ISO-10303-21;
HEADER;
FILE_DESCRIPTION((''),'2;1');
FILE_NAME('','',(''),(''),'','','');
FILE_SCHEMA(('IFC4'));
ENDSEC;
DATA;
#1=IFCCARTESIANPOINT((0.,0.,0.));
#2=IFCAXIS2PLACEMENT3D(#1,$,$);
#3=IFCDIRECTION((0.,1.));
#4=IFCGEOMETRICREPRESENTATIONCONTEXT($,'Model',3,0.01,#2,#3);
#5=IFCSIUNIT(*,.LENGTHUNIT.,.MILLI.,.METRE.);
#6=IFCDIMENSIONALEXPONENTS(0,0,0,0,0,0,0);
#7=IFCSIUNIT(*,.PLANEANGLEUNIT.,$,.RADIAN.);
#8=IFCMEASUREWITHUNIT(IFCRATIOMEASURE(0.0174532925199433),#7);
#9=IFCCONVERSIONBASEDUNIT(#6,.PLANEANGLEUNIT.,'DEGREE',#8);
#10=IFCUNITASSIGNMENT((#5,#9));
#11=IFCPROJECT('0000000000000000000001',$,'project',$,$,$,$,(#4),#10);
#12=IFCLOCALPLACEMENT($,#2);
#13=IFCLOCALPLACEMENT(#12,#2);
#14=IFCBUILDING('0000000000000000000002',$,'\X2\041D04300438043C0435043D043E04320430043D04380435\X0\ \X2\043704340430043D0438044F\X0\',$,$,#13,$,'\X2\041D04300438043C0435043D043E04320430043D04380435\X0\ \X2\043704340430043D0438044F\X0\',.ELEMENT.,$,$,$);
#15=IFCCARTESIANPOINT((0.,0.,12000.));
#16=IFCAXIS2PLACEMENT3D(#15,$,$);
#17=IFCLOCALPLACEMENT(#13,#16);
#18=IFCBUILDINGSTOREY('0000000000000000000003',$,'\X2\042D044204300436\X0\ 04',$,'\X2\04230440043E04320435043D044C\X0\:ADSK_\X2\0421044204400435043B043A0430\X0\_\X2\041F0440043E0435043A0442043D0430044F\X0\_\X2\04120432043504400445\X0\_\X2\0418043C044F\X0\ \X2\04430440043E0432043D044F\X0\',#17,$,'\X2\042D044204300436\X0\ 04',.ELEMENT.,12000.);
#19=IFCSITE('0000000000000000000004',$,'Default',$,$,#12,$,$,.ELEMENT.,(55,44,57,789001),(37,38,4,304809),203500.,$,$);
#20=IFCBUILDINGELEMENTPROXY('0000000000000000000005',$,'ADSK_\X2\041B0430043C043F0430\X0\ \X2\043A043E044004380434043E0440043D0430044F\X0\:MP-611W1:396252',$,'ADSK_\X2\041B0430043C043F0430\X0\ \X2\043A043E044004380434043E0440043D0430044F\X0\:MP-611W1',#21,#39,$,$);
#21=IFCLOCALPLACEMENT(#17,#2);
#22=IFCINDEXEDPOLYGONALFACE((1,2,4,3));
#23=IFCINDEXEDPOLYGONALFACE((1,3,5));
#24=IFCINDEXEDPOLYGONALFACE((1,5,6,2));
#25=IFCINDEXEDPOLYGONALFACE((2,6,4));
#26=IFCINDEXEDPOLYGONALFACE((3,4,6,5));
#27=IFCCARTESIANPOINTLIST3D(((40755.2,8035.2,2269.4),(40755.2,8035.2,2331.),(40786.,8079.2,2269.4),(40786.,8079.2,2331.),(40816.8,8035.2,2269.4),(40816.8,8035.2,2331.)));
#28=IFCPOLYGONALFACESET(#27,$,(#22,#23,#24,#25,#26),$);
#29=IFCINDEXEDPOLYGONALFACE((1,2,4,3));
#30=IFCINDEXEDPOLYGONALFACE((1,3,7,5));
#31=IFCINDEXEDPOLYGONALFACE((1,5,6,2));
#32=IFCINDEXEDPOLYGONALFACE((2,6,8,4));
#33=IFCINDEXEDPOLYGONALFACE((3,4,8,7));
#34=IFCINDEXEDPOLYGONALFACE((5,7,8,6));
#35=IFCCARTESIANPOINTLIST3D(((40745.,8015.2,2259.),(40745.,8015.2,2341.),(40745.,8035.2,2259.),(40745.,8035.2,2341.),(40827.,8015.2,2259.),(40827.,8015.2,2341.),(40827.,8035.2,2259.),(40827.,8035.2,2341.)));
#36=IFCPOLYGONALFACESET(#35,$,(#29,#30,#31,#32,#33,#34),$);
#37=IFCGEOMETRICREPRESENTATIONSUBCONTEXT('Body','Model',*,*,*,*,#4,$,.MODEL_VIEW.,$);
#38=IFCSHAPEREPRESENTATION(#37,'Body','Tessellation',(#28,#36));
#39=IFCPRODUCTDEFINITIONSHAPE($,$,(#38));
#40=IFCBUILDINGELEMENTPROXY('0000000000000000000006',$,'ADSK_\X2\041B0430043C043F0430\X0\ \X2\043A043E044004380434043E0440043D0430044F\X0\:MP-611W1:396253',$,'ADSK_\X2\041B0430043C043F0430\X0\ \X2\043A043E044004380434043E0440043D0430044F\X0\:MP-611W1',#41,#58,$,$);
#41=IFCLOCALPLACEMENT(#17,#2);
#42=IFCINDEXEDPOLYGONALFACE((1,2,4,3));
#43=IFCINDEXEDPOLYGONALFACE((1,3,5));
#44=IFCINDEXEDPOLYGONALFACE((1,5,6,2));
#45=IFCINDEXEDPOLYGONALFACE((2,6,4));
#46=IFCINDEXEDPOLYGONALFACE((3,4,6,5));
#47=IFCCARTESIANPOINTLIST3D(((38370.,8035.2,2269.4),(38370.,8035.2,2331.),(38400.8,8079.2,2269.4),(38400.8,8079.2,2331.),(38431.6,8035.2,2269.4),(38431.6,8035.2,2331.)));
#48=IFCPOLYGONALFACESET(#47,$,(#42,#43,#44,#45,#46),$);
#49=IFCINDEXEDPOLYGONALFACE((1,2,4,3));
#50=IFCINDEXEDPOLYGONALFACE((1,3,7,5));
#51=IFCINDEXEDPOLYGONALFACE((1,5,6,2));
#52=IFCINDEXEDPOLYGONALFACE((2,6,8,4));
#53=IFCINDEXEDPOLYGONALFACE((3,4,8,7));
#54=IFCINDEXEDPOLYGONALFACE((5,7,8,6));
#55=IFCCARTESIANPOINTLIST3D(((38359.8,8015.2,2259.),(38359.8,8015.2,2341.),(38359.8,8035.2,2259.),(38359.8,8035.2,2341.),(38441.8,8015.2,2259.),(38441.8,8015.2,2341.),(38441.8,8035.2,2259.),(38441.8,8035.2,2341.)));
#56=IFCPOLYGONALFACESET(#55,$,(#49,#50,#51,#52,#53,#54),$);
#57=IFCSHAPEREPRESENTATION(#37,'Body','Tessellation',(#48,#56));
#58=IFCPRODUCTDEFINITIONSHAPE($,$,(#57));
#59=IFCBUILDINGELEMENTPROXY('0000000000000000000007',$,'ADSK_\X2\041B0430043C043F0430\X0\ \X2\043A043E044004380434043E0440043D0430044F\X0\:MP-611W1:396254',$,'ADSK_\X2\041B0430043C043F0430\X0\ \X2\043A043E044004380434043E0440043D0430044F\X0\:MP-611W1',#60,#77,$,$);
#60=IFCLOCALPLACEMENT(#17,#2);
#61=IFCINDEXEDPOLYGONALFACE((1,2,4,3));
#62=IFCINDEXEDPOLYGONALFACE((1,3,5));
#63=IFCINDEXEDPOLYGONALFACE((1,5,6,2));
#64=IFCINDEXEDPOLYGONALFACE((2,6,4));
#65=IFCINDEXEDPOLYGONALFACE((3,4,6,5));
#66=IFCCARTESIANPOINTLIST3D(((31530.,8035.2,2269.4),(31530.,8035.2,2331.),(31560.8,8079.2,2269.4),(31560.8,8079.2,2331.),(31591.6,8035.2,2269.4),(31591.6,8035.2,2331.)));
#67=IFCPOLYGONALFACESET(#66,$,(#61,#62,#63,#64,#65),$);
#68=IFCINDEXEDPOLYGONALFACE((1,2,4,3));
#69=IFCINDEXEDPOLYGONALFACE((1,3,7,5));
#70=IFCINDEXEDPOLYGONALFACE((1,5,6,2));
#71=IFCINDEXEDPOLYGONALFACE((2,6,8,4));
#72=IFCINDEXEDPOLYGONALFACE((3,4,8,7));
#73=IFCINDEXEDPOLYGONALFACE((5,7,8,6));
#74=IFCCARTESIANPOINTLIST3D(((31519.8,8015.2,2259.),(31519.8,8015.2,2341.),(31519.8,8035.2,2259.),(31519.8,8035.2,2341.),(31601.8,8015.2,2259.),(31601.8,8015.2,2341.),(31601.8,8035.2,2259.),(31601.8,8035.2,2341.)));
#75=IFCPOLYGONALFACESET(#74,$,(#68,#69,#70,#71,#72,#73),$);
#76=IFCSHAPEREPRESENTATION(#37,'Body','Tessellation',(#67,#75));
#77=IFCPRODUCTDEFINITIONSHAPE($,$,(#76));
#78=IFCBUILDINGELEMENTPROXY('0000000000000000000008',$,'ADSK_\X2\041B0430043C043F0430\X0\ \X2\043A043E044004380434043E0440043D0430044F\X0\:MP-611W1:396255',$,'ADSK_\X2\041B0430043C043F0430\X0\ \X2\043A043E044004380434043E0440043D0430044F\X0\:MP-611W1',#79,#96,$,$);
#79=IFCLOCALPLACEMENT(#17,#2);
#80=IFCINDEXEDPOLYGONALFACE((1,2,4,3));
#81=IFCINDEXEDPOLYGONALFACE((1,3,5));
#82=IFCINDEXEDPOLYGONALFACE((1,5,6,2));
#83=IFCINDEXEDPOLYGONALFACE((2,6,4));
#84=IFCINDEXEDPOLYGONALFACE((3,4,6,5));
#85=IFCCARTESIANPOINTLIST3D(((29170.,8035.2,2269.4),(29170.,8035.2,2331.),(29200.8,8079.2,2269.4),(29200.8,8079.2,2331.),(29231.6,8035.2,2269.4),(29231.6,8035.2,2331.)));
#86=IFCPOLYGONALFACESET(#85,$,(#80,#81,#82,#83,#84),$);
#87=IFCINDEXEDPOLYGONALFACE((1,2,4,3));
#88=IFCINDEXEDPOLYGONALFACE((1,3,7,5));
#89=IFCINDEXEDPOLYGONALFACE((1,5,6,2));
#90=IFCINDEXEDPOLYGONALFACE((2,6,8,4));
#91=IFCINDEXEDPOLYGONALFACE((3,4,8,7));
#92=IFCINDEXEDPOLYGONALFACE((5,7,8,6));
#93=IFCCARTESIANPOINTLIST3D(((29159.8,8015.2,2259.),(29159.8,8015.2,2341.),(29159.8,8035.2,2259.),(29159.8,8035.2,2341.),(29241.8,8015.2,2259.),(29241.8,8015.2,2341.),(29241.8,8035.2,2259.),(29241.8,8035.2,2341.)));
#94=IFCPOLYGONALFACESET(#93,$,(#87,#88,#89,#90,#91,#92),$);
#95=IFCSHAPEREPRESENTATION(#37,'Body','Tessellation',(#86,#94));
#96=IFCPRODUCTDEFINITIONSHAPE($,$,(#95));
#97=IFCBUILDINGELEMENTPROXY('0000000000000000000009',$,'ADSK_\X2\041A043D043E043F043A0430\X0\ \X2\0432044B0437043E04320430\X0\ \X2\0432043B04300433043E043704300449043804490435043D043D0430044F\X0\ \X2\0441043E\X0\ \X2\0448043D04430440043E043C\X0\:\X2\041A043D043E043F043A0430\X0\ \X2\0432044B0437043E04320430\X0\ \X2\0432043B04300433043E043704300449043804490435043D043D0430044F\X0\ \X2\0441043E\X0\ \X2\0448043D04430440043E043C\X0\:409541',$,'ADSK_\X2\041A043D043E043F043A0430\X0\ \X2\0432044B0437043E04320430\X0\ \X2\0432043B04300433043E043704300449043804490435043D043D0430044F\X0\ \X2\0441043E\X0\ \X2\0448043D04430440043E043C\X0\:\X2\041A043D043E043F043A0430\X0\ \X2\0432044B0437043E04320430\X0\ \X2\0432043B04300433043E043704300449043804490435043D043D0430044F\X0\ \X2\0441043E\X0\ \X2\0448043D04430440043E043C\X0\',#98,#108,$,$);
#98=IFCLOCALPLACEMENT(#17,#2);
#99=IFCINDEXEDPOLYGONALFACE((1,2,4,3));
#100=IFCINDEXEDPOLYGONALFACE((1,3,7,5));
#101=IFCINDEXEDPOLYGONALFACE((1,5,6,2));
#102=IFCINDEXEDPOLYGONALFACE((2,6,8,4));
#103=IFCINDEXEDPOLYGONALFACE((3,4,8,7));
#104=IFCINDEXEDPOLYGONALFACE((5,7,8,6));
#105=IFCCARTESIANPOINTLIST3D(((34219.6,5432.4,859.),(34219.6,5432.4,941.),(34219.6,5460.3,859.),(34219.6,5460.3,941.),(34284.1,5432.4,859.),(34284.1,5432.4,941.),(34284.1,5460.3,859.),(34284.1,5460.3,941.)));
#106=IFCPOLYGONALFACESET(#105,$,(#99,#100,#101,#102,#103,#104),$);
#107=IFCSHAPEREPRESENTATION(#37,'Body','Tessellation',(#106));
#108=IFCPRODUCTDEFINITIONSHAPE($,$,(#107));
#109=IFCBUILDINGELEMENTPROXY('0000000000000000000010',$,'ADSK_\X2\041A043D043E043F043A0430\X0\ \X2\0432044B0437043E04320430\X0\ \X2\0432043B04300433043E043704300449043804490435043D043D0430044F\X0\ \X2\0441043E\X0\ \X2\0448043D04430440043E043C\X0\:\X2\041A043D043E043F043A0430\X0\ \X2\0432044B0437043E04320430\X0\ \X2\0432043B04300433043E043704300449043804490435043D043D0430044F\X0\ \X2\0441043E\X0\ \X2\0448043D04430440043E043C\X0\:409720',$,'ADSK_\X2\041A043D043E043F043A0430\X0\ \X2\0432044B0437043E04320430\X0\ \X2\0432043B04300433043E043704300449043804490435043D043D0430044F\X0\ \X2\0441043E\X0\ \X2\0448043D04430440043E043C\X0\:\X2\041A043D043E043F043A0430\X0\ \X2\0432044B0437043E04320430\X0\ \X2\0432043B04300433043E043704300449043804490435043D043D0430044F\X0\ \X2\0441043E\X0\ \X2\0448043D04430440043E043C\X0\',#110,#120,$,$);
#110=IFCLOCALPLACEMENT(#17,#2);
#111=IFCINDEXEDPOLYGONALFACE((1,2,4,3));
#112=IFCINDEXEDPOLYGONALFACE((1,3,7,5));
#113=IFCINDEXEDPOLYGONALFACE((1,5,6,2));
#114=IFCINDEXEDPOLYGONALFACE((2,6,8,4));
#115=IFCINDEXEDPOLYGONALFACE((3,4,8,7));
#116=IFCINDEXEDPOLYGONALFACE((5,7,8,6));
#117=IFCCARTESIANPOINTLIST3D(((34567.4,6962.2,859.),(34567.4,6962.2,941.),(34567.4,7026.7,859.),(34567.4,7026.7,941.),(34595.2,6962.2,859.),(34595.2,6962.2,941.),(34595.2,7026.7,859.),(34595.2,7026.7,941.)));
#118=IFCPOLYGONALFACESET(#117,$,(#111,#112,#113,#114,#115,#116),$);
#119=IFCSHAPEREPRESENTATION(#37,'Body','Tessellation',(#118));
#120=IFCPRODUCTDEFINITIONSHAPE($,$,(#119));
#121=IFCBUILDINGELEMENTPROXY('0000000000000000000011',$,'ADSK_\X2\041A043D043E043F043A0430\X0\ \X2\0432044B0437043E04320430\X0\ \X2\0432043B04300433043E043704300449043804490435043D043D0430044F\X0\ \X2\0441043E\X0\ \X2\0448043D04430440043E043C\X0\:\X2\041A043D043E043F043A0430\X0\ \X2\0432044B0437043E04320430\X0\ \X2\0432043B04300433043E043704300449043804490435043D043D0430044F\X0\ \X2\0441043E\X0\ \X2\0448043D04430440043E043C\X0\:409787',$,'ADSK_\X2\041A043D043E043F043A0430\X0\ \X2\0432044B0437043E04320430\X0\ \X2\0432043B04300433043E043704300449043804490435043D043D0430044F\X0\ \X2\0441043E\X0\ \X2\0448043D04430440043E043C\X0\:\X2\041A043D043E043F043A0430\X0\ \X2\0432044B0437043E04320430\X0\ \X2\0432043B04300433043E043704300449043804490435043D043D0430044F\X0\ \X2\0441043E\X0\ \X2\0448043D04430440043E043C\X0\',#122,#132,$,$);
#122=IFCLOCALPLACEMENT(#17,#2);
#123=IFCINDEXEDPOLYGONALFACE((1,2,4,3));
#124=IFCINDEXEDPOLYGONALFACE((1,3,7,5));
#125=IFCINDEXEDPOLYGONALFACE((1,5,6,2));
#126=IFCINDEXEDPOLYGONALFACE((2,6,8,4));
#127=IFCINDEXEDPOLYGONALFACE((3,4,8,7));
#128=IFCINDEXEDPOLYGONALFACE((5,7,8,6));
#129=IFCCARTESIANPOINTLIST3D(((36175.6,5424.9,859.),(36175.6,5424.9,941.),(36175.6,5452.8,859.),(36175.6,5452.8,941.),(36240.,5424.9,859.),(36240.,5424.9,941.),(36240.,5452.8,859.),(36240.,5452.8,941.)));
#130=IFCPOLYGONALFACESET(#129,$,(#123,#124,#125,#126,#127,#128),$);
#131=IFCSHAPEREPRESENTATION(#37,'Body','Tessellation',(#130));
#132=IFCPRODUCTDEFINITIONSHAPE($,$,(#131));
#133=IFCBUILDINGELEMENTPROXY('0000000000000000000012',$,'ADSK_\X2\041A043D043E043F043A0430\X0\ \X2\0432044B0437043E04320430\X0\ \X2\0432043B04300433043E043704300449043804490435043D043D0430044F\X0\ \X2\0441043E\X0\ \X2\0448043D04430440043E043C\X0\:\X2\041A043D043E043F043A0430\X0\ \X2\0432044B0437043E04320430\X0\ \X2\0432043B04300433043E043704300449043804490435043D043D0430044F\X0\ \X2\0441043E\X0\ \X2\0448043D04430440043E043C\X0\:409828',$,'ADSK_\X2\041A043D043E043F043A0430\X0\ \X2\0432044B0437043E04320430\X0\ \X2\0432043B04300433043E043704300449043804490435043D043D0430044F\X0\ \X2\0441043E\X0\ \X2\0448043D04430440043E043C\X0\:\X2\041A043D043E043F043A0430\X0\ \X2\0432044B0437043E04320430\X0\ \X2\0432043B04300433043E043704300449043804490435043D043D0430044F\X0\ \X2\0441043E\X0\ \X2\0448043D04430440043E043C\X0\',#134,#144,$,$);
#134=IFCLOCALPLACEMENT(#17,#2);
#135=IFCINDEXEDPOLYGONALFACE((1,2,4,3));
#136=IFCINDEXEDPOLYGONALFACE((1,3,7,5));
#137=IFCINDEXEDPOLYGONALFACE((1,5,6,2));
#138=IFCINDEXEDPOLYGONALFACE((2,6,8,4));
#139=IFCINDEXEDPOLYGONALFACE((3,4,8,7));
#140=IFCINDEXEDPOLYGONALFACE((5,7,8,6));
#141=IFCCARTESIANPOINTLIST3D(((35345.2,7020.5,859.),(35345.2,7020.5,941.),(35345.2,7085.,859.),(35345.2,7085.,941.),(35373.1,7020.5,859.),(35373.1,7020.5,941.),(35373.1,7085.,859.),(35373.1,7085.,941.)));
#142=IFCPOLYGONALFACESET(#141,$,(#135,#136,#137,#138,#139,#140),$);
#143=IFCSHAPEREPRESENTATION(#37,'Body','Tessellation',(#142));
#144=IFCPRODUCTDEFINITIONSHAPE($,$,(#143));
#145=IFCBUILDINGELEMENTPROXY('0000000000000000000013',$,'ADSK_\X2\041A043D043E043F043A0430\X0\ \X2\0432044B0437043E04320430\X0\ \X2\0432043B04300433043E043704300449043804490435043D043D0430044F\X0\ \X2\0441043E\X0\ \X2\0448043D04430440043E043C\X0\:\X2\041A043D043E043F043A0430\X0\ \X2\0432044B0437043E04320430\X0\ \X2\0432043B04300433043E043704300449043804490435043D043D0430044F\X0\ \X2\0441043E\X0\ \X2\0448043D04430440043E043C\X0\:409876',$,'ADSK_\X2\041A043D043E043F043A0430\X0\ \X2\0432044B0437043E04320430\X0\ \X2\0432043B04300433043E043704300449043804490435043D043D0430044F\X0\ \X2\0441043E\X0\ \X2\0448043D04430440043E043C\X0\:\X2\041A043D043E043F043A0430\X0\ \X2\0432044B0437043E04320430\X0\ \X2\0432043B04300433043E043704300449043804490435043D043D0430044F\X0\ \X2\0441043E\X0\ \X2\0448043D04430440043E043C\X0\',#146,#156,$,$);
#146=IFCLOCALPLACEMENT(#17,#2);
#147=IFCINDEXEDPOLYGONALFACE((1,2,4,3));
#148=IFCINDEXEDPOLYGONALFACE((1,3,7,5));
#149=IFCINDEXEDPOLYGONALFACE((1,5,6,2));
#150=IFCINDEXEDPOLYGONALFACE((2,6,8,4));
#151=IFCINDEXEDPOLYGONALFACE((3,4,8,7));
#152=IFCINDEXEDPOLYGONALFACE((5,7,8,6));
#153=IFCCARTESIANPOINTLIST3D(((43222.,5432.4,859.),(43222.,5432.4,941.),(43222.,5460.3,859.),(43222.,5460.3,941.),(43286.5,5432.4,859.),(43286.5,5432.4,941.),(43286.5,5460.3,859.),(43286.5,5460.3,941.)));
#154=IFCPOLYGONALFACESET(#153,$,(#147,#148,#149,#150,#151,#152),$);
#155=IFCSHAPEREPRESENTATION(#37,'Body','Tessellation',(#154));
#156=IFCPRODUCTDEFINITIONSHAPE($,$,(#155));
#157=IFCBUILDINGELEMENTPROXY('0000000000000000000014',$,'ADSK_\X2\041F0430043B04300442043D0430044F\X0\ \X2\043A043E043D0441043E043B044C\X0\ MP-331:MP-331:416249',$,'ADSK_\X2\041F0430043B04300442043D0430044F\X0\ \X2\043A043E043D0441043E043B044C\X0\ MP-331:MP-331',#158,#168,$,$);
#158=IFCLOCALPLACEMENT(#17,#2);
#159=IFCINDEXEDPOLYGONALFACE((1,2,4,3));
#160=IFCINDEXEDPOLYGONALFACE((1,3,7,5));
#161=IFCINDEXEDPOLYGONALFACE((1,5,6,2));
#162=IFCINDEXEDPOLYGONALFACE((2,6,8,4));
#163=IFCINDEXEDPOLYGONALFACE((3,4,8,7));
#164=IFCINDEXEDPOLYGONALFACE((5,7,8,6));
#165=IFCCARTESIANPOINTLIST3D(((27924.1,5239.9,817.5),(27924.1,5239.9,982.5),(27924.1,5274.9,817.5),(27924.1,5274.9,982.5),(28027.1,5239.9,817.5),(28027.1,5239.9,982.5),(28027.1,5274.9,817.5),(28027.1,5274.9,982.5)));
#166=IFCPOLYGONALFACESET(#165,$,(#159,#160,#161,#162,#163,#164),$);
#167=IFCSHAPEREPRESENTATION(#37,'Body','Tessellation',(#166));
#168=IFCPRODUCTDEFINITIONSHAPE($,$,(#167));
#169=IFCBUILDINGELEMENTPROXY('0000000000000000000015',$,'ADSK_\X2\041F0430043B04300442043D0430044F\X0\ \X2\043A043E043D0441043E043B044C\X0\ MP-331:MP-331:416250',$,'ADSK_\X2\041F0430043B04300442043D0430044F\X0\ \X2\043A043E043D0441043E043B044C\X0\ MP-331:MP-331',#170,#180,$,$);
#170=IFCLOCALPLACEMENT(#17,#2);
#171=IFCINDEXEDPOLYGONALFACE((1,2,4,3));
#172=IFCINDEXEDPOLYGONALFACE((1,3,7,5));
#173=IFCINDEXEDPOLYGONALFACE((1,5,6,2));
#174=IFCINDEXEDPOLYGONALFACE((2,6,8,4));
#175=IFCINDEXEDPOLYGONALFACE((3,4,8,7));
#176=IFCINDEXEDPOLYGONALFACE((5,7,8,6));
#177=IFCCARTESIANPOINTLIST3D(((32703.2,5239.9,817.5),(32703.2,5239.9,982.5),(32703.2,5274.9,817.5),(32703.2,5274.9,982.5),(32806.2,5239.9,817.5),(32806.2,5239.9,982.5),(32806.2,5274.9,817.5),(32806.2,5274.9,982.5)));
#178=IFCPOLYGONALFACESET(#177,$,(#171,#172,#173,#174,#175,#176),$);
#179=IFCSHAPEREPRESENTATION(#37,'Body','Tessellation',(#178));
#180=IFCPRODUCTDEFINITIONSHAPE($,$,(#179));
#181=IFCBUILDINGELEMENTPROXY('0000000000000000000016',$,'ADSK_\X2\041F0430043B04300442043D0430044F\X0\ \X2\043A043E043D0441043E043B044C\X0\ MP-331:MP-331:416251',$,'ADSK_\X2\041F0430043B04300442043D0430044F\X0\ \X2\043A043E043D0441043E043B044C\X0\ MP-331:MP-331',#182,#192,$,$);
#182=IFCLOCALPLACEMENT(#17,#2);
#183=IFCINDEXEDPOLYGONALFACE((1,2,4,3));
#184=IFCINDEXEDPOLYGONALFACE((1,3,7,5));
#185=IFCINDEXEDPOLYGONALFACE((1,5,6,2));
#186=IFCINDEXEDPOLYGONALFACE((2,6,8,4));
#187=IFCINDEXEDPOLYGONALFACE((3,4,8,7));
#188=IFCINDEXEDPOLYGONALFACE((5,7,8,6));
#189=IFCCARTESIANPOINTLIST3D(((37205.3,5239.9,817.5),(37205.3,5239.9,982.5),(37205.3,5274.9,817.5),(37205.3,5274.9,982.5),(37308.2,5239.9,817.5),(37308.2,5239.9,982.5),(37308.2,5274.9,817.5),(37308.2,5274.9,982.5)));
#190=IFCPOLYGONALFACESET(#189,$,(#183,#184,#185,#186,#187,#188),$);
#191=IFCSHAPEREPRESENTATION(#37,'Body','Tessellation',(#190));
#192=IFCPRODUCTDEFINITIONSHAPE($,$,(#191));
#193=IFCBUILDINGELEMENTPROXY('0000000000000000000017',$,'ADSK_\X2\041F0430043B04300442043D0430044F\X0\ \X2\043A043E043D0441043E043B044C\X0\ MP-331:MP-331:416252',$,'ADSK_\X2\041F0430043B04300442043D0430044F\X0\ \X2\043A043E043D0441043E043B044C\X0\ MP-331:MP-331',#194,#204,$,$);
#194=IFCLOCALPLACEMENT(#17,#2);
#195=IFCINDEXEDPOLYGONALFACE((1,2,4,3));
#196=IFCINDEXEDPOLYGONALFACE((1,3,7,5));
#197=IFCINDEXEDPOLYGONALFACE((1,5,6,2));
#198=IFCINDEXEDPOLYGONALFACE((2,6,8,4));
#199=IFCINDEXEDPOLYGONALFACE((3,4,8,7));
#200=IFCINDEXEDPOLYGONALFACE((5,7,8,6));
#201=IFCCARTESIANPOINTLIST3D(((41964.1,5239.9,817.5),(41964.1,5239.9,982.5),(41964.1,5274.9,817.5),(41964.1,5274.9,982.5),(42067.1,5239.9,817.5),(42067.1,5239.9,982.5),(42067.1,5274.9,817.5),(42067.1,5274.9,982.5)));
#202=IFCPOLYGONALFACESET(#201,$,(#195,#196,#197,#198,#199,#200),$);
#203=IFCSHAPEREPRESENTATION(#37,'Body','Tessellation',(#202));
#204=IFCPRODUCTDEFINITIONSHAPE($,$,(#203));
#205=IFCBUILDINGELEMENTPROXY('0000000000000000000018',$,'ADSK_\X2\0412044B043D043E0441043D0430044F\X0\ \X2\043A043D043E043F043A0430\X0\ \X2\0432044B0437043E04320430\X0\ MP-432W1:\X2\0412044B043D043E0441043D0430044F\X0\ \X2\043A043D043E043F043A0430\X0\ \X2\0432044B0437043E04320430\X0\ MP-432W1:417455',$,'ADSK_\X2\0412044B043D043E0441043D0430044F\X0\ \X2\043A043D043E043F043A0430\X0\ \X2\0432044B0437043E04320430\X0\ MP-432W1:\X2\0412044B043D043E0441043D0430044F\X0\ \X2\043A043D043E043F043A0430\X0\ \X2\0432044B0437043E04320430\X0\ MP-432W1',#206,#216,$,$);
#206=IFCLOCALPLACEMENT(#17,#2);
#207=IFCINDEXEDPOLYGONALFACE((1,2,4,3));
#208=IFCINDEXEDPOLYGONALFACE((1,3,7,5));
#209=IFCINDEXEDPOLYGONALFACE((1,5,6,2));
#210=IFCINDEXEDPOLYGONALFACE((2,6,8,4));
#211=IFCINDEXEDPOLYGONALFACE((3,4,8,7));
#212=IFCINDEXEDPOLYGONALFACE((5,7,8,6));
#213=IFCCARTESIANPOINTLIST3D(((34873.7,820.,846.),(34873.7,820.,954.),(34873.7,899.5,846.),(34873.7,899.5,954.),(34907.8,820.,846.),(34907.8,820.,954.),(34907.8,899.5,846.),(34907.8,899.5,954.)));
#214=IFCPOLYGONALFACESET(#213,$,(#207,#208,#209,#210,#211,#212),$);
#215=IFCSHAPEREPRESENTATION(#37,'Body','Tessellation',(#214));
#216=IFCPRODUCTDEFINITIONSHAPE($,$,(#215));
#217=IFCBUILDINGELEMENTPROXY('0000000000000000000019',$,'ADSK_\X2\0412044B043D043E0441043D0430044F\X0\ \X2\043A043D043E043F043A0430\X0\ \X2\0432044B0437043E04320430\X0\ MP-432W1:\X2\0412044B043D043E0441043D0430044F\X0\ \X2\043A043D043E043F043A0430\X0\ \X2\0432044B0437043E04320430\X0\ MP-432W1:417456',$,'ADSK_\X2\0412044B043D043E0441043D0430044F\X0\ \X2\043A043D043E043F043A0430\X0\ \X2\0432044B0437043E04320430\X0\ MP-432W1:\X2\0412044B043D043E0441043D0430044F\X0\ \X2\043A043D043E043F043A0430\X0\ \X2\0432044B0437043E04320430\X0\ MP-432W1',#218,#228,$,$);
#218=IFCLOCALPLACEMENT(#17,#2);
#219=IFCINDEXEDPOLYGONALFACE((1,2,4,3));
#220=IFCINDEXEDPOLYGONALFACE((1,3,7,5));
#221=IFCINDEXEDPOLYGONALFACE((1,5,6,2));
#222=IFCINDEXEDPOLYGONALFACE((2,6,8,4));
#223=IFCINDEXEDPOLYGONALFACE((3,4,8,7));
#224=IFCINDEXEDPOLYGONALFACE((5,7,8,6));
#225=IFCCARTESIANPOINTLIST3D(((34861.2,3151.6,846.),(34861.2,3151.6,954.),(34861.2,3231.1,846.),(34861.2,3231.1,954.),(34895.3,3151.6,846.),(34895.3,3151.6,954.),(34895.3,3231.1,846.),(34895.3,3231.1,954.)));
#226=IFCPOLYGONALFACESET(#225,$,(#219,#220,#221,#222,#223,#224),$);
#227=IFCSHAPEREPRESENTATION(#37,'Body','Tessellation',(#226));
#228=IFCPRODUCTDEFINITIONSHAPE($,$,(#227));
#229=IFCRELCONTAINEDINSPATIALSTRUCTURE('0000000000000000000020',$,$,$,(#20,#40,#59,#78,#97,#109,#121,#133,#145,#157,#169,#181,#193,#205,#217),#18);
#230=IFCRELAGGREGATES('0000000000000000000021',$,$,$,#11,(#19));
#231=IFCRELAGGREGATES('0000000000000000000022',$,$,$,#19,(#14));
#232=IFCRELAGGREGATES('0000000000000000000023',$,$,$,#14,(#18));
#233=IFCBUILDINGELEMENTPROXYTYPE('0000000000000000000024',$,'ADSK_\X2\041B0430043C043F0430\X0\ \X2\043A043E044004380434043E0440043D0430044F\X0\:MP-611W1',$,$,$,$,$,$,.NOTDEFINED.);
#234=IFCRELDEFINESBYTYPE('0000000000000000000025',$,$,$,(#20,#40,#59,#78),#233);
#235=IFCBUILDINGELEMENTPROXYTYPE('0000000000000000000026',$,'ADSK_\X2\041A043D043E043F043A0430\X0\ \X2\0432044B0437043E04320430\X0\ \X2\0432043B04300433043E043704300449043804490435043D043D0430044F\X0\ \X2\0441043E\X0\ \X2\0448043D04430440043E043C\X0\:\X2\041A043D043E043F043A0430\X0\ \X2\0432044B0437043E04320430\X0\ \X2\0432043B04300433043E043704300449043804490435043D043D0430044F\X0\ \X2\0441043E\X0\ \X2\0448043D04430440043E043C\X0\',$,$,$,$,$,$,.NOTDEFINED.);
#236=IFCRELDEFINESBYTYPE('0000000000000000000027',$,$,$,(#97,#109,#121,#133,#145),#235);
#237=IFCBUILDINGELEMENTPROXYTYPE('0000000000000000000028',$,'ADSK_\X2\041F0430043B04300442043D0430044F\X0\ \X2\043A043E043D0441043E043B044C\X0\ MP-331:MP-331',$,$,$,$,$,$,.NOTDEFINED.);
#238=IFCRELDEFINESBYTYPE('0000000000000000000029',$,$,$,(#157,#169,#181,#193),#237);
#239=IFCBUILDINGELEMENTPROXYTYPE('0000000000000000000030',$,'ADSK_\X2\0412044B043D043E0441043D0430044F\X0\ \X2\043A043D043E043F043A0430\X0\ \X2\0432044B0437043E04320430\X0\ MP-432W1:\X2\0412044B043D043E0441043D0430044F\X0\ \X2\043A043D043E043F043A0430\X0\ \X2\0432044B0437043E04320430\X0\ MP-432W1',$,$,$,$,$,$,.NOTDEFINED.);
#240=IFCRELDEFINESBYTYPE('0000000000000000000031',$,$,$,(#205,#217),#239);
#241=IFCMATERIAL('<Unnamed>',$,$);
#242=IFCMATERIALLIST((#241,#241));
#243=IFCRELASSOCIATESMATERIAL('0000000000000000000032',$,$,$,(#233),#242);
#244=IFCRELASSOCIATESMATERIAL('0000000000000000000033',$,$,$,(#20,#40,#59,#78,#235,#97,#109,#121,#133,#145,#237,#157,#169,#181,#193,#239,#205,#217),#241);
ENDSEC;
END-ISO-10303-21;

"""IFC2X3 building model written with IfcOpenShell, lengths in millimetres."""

from ifc_helpers import new_model, entity, si_unit, converted_unit, direction, frame, origin, origin_2d_with_axis, place, context, subcontext, project, spatial, polyline, rectangle, outline, extrude, source, transform, mapped, material, material_list, type_object, type_shapes, element, save


model = new_model("IFC2X3")

# Units and contexts
model_context = context("Model", 3, precision=0.01, world=origin(), true_north=direction((0.0, 1.0)))
body_context = subcontext(model_context, "Body", "Model", "MODEL_VIEW")
ifc_project = project(units=[si_unit("LENGTHUNIT", "METRE", prefix="MILLI"), converted_unit("PLANEANGLEUNIT", "DEGREE", entity("IfcRatioMeasure", 0.0174532925199433), si_unit("PLANEANGLEUNIT", "RADIAN"), dimensions=[0, 0, 0, 0, 0, 0, 0])], contexts=[model_context])

# Site, building, storey
site_placement = place(None, origin())
site = spatial("IfcSite", under=ifc_project, at=site_placement, Name="Default", CompositionType="ELEMENT", RefLatitude=(55, 44, 57, 789001), RefLongitude=(37, 38, 4, 304809), RefElevation=203500.0)
building_placement = place(site_placement, origin())
building = spatial("IfcBuilding", under=site, at=building_placement, Name="Наименование здания", LongName="Наименование здания", CompositionType="ELEMENT")
storey_placement = place(building_placement, frame((0.0, 0.0, 12000.0)))
storey = spatial("IfcBuildingStorey", under=building, at=storey_placement, Name="Этаж 04", ObjectType="Уровень:ADSK_Стрелка_Проектная_Вверх_Имя уровня", LongName="Этаж 04", CompositionType="ELEMENT", Elevation=12000.0)

# Building element proxies
ifc_material = material(Name="<Unnamed>")
ifc_material_list = material_list([ifc_material, ifc_material])
building_element_proxy_type_1 = type_object("IfcBuildingElementProxyType", Name="ADSK_Лампа коридорная:MP-611W1", PredefinedType="NOTDEFINED", material=ifc_material_list)
shared_shape_1 = source(origin(), body_context, "Body", "SweptSolid", [
    extrude(outline(polyline([(-30.8, -14.7), (30.8, -14.7), (0.0, 29.3), (-30.8, -14.7)])), frame((0.0, -2.7, -30.6), z_axis=(0.0, 0.0, 1.0), x_axis=(-1.0, 0.0, 0.0)), (0.0, 0.0, 1.0), 61.6),
    extrude(rectangle(XDim=82.0, YDim=20.0, at=origin_2d_with_axis()), frame((0.0, 22.0, -41.0), z_axis=(0.0, 0.0, 1.0), x_axis=(-1.0, 0.0, 0.0)), (0.0, 0.0, 1.0), 82.0),
])
type_shapes(building_element_proxy_type_1, [shared_shape_1])
for number, where, z_axis, x_axis, name in (
    (1, (40786.0, 8047.1, 2300.0), (0.0, 0.0, 1.0), (-1.0, 0.0, 0.0), "ADSK_Лампа коридорная:MP-611W1:396252"),
    (2, (38400.8, 8047.1, 2300.0), (0.0, 0.0, 1.0), (-1.0, 0.0, 0.0), "ADSK_Лампа коридорная:MP-611W1:396253"),
    (3, (31560.8, 8047.1, 2300.0), (0.0, 0.0, 1.0), (-1.0, 0.0, 0.0), "ADSK_Лампа коридорная:MP-611W1:396254"),
    (4, (29200.8, 8047.1, 2300.0), (0.0, 0.0, 1.0), (-1.0, 0.0, 0.0), "ADSK_Лампа коридорная:MP-611W1:396255"),
):
    element("IfcBuildingElementProxy", number, at=place(storey_placement, frame(where, z_axis=z_axis, x_axis=x_axis)), inside=storey, type_object=building_element_proxy_type_1, material=ifc_material, Name=name, ObjectType="ADSK_Лампа коридорная:MP-611W1", context=body_context, shape_type="MappedRepresentation", body=[
        mapped(shared_shape_1, transform((0.0, 0.0, 0.0), scale=1.0)),
    ])
building_element_proxy_type_2 = type_object("IfcBuildingElementProxyType", Name="ADSK_Кнопка вызова влагозащищенная со шнуром:Кнопка вызова влагозащищенная со шнуром", PredefinedType="NOTDEFINED", material=ifc_material)
shared_shape_2 = source(origin(), body_context, "Body", "SweptSolid", [
    extrude(rectangle(XDim=64.5, YDim=27.8, at=origin_2d_with_axis()), frame((32.2, 13.9, 0.0), z_axis=(0.0, 0.0, 1.0), x_axis=(-1.0, 0.0, 0.0)), (0.0, 0.0, 1.0), 82.0),
])
type_shapes(building_element_proxy_type_2, [shared_shape_2])
for number, where, z_axis, x_axis, name in (
    (5, (34284.1, 5460.3, 859.0), (0.0, 0.0, 1.0), (-1.0, 0.0, 0.0), "ADSK_Кнопка вызова влагозащищенная со шнуром:Кнопка вызова влагозащищенная со шнуром:409541"),
    (6, (34567.4, 7026.7, 859.0), (0.0, 0.0, 1.0), (0.0, -1.0, 0.0), "ADSK_Кнопка вызова влагозащищенная со шнуром:Кнопка вызова влагозащищенная со шнуром:409720"),
    (7, (36240.1, 5452.8, 859.0), (0.0, 0.0, 1.0), (-1.0, 0.0, 0.0), "ADSK_Кнопка вызова влагозащищенная со шнуром:Кнопка вызова влагозащищенная со шнуром:409787"),
    (8, (35373.1, 7020.5, 859.0), (0.0, 0.0, 1.0), (0.0, 1.0, 0.0), "ADSK_Кнопка вызова влагозащищенная со шнуром:Кнопка вызова влагозащищенная со шнуром:409828"),
    (9, (43286.5, 5460.3, 859.0), (0.0, 0.0, 1.0), (-1.0, 0.0, 0.0), "ADSK_Кнопка вызова влагозащищенная со шнуром:Кнопка вызова влагозащищенная со шнуром:409876"),
):
    element("IfcBuildingElementProxy", number, at=place(storey_placement, frame(where, z_axis=z_axis, x_axis=x_axis)), inside=storey, type_object=building_element_proxy_type_2, material=ifc_material, Name=name, ObjectType="ADSK_Кнопка вызова влагозащищенная со шнуром:Кнопка вызова влагозащищенная со шнуром", context=body_context, shape_type="MappedRepresentation", body=[
        mapped(shared_shape_2, transform((0.0, 0.0, 0.0), scale=1.0)),
    ])
building_element_proxy_type_3 = type_object("IfcBuildingElementProxyType", Name="ADSK_Палатная консоль MP-331:MP-331", PredefinedType="NOTDEFINED", material=ifc_material)
shared_shape_3 = source(origin(), body_context, "Body", "SweptSolid", [
    extrude(rectangle(XDim=103.0, YDim=35.0, at=origin_2d_with_axis()), frame((0.0, 14.5, -82.5), z_axis=(0.0, 0.0, 1.0), x_axis=(-1.0, 0.0, 0.0)), (0.0, 0.0, 1.0), 165.0),
])
type_shapes(building_element_proxy_type_3, [shared_shape_3])
for number, where, name in (
    (10, (27975.6, 5242.9, 900.0), "ADSK_Палатная консоль MP-331:MP-331:416249"),
    (11, (32754.7, 5242.9, 900.0), "ADSK_Палатная консоль MP-331:MP-331:416250"),
    (12, (37256.8, 5242.9, 900.0), "ADSK_Палатная консоль MP-331:MP-331:416251"),
    (13, (42015.6, 5242.9, 900.0), "ADSK_Палатная консоль MP-331:MP-331:416252"),
):
    element("IfcBuildingElementProxy", number, at=place(storey_placement, frame(where)), inside=storey, type_object=building_element_proxy_type_3, material=ifc_material, Name=name, ObjectType="ADSK_Палатная консоль MP-331:MP-331", context=body_context, shape_type="MappedRepresentation", body=[
        mapped(shared_shape_3, transform((0.0, 0.0, 0.0), scale=1.0)),
    ])
building_element_proxy_type_4 = type_object("IfcBuildingElementProxyType", Name="ADSK_Выносная кнопка вызова MP-432W1:Выносная кнопка вызова MP-432W1", PredefinedType="NOTDEFINED", material=ifc_material)
shared_shape_4 = source(origin(), body_context, "Body", "SweptSolid", [
    extrude(rectangle(XDim=79.5, YDim=34.1, at=origin_2d_with_axis()), frame((0.0, 15.0, -54.0), z_axis=(0.0, 0.0, 1.0), x_axis=(-1.0, 0.0, 0.0)), (0.0, 0.0, 1.0), 108.0),
])
type_shapes(building_element_proxy_type_4, [shared_shape_4])
for number, where, z_axis, x_axis, name in (
    (14, (34875.8, 859.8, 900.0), (0.0, 0.0, 1.0), (0.0, -1.0, 0.0), "ADSK_Выносная кнопка вызова MP-432W1:Выносная кнопка вызова MP-432W1:417455"),
    (15, (34863.2, 3191.3, 900.0), (0.0, 0.0, 1.0), (0.0, -1.0, 0.0), "ADSK_Выносная кнопка вызова MP-432W1:Выносная кнопка вызова MP-432W1:417456"),
):
    element("IfcBuildingElementProxy", number, at=place(storey_placement, frame(where, z_axis=z_axis, x_axis=x_axis)), inside=storey, type_object=building_element_proxy_type_4, material=ifc_material, Name=name, ObjectType="ADSK_Выносная кнопка вызова MP-432W1:Выносная кнопка вызова MP-432W1", context=body_context, shape_type="MappedRepresentation", body=[
        mapped(shared_shape_4, transform((0.0, 0.0, 0.0), scale=1.0)),
    ])

save(model, "model.ifc")
